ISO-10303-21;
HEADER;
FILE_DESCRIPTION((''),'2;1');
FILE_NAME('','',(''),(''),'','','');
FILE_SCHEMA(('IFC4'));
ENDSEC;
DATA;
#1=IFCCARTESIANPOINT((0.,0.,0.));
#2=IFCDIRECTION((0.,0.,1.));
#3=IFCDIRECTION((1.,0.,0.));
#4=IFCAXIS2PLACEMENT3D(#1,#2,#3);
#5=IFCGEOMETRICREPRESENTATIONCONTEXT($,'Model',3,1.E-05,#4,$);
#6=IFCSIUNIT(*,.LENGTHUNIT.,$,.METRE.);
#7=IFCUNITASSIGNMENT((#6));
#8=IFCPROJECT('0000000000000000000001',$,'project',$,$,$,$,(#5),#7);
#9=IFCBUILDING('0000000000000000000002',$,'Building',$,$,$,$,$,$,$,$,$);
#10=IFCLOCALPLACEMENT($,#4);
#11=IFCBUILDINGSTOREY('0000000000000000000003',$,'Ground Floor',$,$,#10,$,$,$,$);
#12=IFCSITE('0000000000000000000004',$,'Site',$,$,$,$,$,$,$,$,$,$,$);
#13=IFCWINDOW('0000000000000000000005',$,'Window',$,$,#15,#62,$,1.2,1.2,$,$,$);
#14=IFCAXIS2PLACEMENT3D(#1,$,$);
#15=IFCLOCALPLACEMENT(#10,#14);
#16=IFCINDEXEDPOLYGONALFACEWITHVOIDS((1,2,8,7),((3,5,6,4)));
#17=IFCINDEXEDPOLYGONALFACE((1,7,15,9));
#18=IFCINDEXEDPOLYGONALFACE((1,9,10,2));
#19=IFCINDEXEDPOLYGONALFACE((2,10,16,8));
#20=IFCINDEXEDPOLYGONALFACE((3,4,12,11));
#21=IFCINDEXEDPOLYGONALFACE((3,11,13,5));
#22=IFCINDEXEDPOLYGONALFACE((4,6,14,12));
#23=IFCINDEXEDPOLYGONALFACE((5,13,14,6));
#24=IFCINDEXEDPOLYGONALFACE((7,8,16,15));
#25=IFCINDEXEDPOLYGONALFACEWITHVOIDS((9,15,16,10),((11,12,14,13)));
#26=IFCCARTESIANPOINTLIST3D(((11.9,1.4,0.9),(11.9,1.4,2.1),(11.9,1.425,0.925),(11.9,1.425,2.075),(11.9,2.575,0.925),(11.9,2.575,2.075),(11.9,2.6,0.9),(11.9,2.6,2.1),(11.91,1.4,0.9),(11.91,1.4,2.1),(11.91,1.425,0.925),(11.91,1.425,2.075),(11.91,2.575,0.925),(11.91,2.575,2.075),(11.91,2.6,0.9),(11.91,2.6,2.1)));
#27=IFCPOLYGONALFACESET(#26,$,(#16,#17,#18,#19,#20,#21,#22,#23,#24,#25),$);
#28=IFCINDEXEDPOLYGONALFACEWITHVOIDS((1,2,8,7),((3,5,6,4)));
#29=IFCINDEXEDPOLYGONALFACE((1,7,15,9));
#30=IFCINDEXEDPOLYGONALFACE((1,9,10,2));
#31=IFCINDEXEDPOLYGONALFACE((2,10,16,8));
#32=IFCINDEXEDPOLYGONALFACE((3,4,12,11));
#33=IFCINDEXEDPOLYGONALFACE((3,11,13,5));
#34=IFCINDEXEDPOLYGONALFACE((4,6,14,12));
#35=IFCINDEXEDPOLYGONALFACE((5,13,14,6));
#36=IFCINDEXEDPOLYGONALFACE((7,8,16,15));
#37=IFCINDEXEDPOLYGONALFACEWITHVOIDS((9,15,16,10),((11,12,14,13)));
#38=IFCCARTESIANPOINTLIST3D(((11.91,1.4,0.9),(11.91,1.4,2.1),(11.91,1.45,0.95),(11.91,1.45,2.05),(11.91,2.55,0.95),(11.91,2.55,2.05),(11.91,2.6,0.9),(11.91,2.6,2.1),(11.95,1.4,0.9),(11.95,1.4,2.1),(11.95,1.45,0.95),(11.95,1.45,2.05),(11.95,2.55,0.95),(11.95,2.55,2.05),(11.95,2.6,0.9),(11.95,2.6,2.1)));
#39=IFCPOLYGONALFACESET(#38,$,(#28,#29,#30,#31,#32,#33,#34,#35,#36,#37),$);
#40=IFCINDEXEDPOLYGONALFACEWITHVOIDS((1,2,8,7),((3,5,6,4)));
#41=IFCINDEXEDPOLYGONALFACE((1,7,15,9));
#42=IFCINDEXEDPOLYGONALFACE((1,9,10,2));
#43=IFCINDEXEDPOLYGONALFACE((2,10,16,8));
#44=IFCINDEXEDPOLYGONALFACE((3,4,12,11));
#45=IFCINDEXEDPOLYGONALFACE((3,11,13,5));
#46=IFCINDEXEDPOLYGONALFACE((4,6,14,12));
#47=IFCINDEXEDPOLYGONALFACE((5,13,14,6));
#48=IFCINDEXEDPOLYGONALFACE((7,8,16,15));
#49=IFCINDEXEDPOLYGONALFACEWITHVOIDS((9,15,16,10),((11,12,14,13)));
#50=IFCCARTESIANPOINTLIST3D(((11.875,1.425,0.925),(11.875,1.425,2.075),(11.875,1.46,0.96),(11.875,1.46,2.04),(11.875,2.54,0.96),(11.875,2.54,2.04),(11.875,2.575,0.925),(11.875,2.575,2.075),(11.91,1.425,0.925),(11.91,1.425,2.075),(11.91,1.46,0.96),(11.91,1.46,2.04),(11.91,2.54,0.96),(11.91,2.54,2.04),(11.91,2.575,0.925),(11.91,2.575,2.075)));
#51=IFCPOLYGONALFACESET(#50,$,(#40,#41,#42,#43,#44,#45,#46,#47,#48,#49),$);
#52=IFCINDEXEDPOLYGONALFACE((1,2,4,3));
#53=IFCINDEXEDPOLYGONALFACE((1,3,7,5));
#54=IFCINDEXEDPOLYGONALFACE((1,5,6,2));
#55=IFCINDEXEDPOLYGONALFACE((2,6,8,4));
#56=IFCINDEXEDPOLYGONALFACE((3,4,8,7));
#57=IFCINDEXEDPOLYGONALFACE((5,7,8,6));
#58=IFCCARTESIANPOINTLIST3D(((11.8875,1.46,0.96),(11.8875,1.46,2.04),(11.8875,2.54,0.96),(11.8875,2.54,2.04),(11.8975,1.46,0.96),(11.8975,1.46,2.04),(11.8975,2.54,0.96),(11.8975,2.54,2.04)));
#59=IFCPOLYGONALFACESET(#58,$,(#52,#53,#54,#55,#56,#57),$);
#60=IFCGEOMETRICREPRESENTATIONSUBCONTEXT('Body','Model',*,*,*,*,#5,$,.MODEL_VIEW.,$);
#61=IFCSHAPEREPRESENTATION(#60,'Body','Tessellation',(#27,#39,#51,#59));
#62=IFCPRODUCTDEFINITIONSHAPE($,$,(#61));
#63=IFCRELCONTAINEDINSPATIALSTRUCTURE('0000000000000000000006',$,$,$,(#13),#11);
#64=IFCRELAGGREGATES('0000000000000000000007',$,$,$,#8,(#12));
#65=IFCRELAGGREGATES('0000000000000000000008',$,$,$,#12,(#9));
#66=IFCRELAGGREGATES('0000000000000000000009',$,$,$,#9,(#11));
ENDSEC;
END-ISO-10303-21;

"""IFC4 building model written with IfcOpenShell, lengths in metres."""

from ifc_helpers import new_model, si_unit, frame, origin_with_axes, place, context, subcontext, project, spatial, line, indexed_curve, outline, extrude, element, save


model = new_model("IFC4")

# Units and contexts
model_context = context("Model", 3, precision=1e-05, world=origin_with_axes())
body_context = subcontext(model_context, "Body", "Model", "MODEL_VIEW")
ifc_project = project(units=[si_unit("LENGTHUNIT", "METRE")], contexts=[model_context])

# Site, building, storey
site = spatial("IfcSite", under=ifc_project, Name="Site")
building = spatial("IfcBuilding", under=site, Name="Building")
storey_placement = place(None, origin_with_axes())
storey = spatial("IfcBuildingStorey", under=building, at=storey_placement, Name="Ground Floor")

# Window
window_1_placement = place(storey_placement, frame((12.0, 1.4, 0.9), z_axis=(0.0, 0.0, 1.0), x_axis=(0.0, 1.0, 0.0)))
element("IfcWindow", 1, at=window_1_placement, inside=storey, Name="Window", OverallHeight=1.2, OverallWidth=1.2, context=body_context, shape_type="SweptSolid", body=[
    extrude(outline(indexed_curve([(0.0, 0.0), (1.2, 0.0), (1.2, 1.2), (0.0, 1.2)], segments=[line(1, 2, 3, 4, 1)]), holes=[indexed_curve([(0.025, 0.025), (1.175, 0.025), (1.175, 1.175), (0.025, 1.175)], segments=[line(1, 2, 3, 4, 1)])]), frame((0.0, 0.09, 0.0), z_axis=(0.0, -1.0, 0.0), x_axis=(1.0, 0.0, 0.0)), (0.0, 0.0, -1.0), 0.01),
    extrude(outline(indexed_curve([(0.0, 0.0), (1.2, 0.0), (1.2, 1.2), (0.0, 1.2)], segments=[line(1, 2, 3, 4, 1)]), holes=[indexed_curve([(0.05, 0.05), (1.15, 0.05), (1.15, 1.15), (0.05, 1.15)], segments=[line(1, 2, 3, 4, 1)])]), frame((0.0, 0.05, 0.0), z_axis=(0.0, -1.0, 0.0), x_axis=(1.0, 0.0, 0.0)), (0.0, 0.0, -1.0), 0.04),
    extrude(outline(indexed_curve([(0.0, 0.0), (1.15, 0.0), (1.15, 1.15), (0.0, 1.15)], segments=[line(1, 2, 3, 4, 1)]), holes=[indexed_curve([(0.035, 0.035), (1.115, 0.035), (1.115, 1.115), (0.035, 1.115)], segments=[line(1, 2, 3, 4, 1)])]), frame((0.025, 0.09, 0.025), z_axis=(0.0, -1.0, 0.0), x_axis=(1.0, 0.0, 0.0)), (0.0, 0.0, -1.0), 0.035),
    extrude(outline(indexed_curve([(0.035, 0.035), (1.115, 0.035), (1.115, 1.115), (0.035, 1.115)], segments=[line(1, 2, 3, 4, 1)])), frame((0.025, 0.1025, 0.025), z_axis=(0.0, -1.0, 0.0), x_axis=(1.0, 0.0, 0.0)), (0.0, 0.0, -1.0), 0.01),
])

save(model, "model.ifc")
